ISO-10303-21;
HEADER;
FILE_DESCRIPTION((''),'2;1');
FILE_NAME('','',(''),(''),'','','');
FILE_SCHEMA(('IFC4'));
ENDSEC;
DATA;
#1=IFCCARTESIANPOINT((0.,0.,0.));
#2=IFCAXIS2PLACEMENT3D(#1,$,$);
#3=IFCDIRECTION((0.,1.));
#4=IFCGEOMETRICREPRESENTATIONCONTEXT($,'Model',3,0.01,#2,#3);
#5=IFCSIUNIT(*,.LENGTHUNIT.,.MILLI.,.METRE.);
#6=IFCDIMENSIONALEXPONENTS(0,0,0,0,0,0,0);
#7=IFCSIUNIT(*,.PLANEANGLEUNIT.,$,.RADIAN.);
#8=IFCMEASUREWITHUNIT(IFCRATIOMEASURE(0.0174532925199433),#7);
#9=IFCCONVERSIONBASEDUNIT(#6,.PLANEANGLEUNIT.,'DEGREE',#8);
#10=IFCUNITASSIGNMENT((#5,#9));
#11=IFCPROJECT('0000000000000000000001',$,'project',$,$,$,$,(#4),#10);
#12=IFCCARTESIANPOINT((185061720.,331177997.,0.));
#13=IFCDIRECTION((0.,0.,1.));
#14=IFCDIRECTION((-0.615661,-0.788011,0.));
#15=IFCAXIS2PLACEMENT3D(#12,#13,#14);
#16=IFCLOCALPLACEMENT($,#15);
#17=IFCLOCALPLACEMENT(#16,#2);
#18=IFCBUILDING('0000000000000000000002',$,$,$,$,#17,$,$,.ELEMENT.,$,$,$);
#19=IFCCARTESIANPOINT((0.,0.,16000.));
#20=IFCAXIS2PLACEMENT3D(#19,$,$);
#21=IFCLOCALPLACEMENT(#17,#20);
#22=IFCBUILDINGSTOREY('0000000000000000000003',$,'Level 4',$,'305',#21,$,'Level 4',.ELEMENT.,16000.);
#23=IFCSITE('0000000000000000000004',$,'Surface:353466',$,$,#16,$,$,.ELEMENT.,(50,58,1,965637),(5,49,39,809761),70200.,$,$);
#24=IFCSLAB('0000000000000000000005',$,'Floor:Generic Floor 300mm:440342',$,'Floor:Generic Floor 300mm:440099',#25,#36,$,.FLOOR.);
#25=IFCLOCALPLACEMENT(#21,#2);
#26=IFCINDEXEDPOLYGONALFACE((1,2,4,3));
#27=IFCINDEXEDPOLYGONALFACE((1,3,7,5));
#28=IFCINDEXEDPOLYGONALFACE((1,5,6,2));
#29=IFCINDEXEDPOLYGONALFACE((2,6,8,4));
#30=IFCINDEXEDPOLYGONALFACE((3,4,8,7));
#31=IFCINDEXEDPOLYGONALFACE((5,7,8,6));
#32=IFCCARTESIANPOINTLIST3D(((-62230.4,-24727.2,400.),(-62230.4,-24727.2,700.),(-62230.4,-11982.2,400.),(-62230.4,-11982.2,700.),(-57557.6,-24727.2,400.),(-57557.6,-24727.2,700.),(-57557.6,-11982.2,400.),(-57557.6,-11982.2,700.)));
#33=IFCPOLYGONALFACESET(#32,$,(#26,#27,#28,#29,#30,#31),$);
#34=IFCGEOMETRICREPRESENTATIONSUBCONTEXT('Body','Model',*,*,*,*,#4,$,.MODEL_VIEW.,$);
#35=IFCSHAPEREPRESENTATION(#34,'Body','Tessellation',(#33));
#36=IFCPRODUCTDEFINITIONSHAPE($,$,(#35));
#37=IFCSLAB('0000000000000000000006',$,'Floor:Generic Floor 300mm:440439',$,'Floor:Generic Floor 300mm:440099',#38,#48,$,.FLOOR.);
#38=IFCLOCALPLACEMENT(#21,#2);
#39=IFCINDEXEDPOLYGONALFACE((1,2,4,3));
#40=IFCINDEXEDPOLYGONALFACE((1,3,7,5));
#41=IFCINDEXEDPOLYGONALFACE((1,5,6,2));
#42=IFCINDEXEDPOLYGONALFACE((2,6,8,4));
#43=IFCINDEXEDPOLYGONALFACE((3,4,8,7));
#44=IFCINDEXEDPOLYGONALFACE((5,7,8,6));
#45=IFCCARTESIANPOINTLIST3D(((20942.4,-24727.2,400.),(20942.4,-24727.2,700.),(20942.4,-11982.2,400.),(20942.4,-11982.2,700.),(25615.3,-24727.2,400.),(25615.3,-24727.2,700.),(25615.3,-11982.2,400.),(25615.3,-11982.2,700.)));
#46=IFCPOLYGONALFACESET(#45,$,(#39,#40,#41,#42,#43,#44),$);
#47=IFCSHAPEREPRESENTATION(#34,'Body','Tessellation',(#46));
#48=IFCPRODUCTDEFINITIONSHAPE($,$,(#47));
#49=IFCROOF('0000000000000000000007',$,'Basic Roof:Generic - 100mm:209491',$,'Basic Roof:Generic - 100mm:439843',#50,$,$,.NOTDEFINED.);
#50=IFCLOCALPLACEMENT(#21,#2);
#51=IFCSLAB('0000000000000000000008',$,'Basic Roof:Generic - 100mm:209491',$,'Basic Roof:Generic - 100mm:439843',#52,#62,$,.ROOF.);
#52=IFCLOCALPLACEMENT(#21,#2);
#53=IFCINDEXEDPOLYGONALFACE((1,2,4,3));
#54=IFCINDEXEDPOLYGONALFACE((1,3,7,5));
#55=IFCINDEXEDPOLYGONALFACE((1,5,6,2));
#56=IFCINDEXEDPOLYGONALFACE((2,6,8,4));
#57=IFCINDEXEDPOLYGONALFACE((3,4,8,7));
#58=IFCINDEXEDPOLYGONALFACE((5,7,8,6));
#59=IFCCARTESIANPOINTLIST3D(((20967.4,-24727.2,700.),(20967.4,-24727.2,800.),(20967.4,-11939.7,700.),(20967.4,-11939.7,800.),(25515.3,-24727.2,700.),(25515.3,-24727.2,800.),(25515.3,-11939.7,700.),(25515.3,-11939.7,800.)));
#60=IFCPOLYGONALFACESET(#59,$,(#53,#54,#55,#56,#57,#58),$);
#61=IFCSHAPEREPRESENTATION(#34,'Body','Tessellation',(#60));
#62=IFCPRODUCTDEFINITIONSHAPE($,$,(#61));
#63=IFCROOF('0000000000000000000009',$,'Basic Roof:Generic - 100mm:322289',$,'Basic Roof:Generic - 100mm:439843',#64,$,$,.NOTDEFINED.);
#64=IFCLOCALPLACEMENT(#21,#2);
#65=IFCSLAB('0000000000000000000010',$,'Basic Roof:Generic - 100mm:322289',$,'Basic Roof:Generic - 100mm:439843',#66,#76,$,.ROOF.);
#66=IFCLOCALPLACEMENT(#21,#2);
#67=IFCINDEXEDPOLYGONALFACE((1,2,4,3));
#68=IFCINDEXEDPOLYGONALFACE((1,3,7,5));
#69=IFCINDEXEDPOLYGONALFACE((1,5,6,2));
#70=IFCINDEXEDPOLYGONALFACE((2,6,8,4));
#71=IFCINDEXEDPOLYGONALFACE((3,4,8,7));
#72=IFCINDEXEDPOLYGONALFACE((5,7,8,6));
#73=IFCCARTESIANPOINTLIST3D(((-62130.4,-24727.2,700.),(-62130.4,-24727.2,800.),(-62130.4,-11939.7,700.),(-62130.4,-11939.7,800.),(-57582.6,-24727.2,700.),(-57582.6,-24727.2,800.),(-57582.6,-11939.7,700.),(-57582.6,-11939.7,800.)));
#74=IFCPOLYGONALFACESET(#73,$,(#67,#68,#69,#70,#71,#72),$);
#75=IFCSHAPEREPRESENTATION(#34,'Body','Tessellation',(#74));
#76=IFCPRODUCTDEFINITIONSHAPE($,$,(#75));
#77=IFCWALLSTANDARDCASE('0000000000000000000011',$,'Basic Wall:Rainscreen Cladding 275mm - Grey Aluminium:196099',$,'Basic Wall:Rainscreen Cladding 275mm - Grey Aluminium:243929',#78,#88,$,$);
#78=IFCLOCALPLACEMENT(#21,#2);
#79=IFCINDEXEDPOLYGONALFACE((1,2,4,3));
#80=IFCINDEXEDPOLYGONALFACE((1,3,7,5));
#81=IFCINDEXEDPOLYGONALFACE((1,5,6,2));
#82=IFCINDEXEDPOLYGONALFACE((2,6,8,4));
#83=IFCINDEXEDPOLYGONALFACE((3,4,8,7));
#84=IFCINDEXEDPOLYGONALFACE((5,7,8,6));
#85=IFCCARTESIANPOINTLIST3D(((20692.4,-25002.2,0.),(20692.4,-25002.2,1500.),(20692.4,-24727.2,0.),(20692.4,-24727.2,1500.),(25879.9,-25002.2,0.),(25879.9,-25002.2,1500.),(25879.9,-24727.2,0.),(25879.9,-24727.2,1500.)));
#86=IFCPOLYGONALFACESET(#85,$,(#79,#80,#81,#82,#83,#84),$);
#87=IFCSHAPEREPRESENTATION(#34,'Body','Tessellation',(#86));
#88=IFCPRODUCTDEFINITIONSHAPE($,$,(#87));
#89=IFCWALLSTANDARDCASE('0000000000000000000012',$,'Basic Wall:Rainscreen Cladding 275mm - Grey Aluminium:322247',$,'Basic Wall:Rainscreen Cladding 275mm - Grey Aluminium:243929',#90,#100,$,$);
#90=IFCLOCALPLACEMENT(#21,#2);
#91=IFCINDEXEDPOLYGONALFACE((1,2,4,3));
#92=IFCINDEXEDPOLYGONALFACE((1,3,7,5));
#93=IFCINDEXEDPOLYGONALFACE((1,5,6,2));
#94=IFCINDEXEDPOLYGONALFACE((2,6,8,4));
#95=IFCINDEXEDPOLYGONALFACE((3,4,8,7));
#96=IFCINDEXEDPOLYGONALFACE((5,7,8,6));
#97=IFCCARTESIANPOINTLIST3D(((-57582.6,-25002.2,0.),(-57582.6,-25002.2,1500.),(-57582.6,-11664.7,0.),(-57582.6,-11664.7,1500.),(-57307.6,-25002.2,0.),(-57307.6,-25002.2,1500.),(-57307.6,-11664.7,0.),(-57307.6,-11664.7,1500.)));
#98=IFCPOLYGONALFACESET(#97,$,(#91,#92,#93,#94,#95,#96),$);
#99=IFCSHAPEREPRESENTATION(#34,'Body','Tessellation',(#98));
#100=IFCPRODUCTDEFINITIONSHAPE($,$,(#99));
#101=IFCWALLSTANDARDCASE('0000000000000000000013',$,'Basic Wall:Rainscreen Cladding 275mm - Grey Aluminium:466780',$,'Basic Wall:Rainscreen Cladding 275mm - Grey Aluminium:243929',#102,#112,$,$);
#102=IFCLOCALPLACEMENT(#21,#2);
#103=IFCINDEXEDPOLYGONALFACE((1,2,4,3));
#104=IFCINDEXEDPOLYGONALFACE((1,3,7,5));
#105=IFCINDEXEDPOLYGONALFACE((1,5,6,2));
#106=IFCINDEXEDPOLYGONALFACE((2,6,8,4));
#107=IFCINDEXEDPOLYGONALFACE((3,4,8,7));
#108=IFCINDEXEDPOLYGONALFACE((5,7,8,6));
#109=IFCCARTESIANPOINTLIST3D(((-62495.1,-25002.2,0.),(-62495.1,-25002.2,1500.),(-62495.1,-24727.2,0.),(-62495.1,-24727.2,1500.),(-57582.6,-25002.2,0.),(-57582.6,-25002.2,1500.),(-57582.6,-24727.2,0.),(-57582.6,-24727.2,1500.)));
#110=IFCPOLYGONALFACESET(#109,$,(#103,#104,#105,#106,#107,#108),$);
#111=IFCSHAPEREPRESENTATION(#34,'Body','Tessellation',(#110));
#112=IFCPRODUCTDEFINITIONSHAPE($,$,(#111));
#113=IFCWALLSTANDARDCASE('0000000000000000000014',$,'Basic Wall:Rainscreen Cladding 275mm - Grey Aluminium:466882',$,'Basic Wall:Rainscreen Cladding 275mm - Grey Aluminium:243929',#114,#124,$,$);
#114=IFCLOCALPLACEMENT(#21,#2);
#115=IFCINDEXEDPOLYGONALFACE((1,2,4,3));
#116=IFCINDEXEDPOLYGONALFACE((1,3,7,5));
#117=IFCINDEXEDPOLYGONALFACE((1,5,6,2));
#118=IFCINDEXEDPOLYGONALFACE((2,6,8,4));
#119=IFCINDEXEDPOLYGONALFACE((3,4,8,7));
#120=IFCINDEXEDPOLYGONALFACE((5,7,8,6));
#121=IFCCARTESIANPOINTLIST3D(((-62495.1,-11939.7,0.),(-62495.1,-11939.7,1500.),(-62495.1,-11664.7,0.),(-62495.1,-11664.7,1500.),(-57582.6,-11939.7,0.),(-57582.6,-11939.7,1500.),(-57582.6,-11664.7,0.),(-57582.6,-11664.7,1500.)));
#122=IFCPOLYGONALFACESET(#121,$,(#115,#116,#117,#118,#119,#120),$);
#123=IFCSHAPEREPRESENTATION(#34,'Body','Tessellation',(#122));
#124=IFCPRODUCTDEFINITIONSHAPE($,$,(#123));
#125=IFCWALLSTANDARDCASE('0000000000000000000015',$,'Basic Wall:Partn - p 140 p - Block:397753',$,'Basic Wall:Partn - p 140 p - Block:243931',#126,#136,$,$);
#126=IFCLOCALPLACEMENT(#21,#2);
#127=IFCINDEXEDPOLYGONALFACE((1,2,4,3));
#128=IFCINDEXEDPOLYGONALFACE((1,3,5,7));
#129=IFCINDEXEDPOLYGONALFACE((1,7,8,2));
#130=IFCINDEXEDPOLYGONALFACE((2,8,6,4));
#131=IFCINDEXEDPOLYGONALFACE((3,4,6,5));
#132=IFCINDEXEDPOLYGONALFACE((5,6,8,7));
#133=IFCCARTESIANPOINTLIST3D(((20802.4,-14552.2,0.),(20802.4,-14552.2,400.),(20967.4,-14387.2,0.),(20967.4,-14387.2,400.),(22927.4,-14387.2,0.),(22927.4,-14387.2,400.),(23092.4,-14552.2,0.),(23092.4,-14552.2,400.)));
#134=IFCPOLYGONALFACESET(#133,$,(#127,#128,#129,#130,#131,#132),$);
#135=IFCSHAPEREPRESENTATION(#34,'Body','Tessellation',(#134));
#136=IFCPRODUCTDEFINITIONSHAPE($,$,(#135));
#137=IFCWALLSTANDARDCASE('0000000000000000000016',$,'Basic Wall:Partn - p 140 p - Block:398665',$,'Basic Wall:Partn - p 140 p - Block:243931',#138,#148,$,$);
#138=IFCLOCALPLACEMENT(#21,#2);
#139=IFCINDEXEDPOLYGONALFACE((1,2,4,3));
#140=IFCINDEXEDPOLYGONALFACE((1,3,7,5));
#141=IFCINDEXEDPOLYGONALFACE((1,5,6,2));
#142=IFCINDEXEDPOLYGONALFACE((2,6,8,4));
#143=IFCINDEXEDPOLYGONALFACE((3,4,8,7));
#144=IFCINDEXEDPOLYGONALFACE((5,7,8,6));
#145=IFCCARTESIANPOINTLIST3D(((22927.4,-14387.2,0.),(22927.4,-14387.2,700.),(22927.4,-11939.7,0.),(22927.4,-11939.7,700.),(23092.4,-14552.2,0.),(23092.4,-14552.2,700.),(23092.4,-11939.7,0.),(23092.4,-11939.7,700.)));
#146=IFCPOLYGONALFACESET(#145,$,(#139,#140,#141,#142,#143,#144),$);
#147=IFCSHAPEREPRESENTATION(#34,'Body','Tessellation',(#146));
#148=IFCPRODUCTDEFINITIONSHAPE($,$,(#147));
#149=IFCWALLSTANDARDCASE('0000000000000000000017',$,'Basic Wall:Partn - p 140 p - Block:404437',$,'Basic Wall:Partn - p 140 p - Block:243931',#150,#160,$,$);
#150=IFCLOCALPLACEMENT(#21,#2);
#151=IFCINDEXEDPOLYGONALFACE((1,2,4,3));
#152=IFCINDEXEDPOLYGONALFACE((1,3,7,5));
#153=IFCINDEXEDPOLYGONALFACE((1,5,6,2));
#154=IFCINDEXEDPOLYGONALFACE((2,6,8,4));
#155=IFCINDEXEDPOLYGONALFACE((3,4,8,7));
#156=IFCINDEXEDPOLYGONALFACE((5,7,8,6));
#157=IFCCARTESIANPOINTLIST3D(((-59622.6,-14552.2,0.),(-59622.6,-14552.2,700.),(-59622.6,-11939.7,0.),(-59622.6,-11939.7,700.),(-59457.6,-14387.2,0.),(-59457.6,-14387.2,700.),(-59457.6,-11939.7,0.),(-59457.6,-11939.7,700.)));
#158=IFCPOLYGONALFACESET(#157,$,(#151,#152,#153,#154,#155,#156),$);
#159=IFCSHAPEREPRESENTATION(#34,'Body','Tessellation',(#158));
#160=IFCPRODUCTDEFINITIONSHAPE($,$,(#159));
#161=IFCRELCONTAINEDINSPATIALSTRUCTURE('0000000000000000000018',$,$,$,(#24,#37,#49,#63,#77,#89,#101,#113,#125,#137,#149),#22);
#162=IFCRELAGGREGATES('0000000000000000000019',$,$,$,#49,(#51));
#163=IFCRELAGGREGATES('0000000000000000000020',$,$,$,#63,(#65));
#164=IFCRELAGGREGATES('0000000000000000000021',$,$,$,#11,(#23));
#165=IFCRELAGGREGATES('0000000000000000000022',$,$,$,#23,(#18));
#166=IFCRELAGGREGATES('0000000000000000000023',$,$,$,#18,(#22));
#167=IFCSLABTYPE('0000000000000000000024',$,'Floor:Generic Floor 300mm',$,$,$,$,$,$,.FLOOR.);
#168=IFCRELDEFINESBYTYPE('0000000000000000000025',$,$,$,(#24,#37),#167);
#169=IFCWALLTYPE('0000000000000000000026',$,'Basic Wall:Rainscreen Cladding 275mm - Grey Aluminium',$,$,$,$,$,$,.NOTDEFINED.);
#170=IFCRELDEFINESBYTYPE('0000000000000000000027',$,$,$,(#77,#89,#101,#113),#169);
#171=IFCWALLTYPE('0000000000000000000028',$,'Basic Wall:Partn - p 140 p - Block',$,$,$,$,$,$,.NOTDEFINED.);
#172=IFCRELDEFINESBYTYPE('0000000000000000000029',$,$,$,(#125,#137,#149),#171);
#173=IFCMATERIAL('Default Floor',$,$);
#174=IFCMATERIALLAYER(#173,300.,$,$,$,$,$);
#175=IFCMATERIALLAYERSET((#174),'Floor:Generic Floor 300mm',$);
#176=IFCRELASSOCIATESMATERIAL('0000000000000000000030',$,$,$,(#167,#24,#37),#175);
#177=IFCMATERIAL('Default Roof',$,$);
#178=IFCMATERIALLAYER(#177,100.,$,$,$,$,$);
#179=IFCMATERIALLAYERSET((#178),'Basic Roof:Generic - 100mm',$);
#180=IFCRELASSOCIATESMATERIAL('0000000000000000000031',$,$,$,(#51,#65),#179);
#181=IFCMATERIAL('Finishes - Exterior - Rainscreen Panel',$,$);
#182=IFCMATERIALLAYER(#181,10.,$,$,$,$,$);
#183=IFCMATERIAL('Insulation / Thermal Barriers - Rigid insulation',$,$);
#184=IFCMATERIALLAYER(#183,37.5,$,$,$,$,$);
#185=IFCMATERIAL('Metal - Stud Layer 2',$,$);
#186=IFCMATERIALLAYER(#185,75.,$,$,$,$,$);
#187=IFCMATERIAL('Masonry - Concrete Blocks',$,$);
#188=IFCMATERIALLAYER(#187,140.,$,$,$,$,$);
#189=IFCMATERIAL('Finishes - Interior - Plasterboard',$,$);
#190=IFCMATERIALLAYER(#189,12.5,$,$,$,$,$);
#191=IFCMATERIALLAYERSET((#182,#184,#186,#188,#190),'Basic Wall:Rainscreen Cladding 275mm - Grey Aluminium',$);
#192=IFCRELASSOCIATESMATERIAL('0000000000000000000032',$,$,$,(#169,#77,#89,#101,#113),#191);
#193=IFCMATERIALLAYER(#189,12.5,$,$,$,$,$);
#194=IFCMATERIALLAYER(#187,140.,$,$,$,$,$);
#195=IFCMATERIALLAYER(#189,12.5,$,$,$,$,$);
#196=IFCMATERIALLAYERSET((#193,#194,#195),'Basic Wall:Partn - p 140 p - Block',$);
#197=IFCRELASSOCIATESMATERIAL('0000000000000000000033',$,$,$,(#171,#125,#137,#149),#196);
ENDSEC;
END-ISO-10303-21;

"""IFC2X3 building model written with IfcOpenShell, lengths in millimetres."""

from ifc_helpers import new_model, entity, si_unit, converted_unit, direction, frame, frame_2d, origin, origin_2d_with_axis, place, context, subcontext, project, spatial, polyline, rectangle, outline, extrude, clip, halfspace, bounded_halfspace, material, layer, layer_set, layer_usage, type_object, element, aggregate, save


model = new_model("IFC2X3")

# Units and contexts
model_context = context("Model", 3, precision=0.01, world=origin(), true_north=direction((0.0, 1.0)))
body_context = subcontext(model_context, "Body", "Model", "MODEL_VIEW")
ifc_project = project(units=[si_unit("LENGTHUNIT", "METRE", prefix="MILLI"), converted_unit("PLANEANGLEUNIT", "DEGREE", entity("IfcRatioMeasure", 0.0174532925199433), si_unit("PLANEANGLEUNIT", "RADIAN"), dimensions=[0, 0, 0, 0, 0, 0, 0])], contexts=[model_context])

# Site, building, storey
site_placement = place(None, frame((185061720.0, 331177997.0, 0.0), z_axis=(0.0, 0.0, 1.0), x_axis=(-0.615661, -0.788011, 0.0)))
site = spatial("IfcSite", under=ifc_project, at=site_placement, Name="Surface:353466", CompositionType="ELEMENT", RefLatitude=(50, 58, 1, 965637), RefLongitude=(5, 49, 39, 809761), RefElevation=70200.0)
building_placement = place(site_placement, origin())
building = spatial("IfcBuilding", under=site, at=building_placement, CompositionType="ELEMENT")
storey_placement = place(building_placement, frame((0.0, 0.0, 16000.0)))
storey = spatial("IfcBuildingStorey", under=building, at=storey_placement, Name="Level 4", ObjectType="305", LongName="Level 4", CompositionType="ELEMENT", Elevation=16000.0)

# Slabs
ifc_material_1 = material(Name="Default Floor")
ifc_layer_1 = layer(ifc_material_1, 300.0)
ifc_layer_set_1 = layer_set([ifc_layer_1], Name="Floor:Generic Floor 300mm")
ifc_layer_usage_1 = layer_usage(ifc_layer_set_1, "AXIS3", "POSITIVE", 0.0)
slab_type = type_object("IfcSlabType", Name="Floor:Generic Floor 300mm", PredefinedType="FLOOR", material=ifc_layer_set_1)
slab_1_placement = place(storey_placement, origin())
element("IfcSlab", 1, at=slab_1_placement, inside=storey, type_object=slab_type, material=ifc_layer_usage_1, Name="Floor:Generic Floor 300mm:440342", ObjectType="Floor:Generic Floor 300mm:440099", PredefinedType="FLOOR", context=body_context, shape_type="SweptSolid", body=[
    extrude(rectangle(XDim=12745.0, YDim=4672.9, at=frame_2d((0.0, 0.0), x_axis=(1.0, 0.0))), frame((-59894.0, -18354.7, 700.0), z_axis=(0.0, 0.0, -1.0), x_axis=(0.0, 1.0, 0.0)), (0.0, 0.0, 1.0), 300.0),
])
ifc_layer_usage_2 = layer_usage(ifc_layer_set_1, "AXIS3", "POSITIVE", 0.0)
slab_2_placement = place(storey_placement, origin())
element("IfcSlab", 2, at=slab_2_placement, inside=storey, type_object=slab_type, material=ifc_layer_usage_2, Name="Floor:Generic Floor 300mm:440439", ObjectType="Floor:Generic Floor 300mm:440099", PredefinedType="FLOOR", context=body_context, shape_type="SweptSolid", body=[
    extrude(rectangle(XDim=12745.0, YDim=4672.9, at=origin_2d_with_axis()), frame((23278.9, -18354.7, 700.0), z_axis=(0.0, 0.0, -1.0), x_axis=(0.0, 1.0, 0.0)), (0.0, 0.0, 1.0), 300.0),
])

# Roofs, slabs
roof_1_placement = place(storey_placement, frame((20967.4, -24727.2, 700.0)))
roof_1 = element("IfcRoof", 3, at=roof_1_placement, inside=storey, Name="Basic Roof:Generic - 100mm:209491", ObjectType="Basic Roof:Generic - 100mm:439843", ShapeType="NOTDEFINED")
ifc_material_2 = material(Name="Default Roof")
ifc_layer_2 = layer(ifc_material_2, 100.0)
ifc_layer_set_2 = layer_set([ifc_layer_2], Name="Basic Roof:Generic - 100mm")
slab_3_placement = place(roof_1_placement, origin())
slab_3 = element("IfcSlab", 4, at=slab_3_placement, material=ifc_layer_set_2, Name="Basic Roof:Generic - 100mm:209491", ObjectType="Basic Roof:Generic - 100mm:439843", PredefinedType="ROOF", context=body_context, shape_type="SweptSolid", body=[
    extrude(rectangle(XDim=4547.9, YDim=12787.5, at=frame_2d((0.0, 0.0), x_axis=(1.0, 0.0))), frame((2273.9, 6393.8, 0.0)), (0.0, 0.0, 1.0), 100.0),
])
aggregate(roof_1, [slab_3])
roof_2_placement = place(storey_placement, frame((-62130.4, -24727.2, 700.0)))
roof_2 = element("IfcRoof", 5, at=roof_2_placement, inside=storey, Name="Basic Roof:Generic - 100mm:322289", ObjectType="Basic Roof:Generic - 100mm:439843", ShapeType="NOTDEFINED")
slab_4_placement = place(roof_2_placement, origin())
slab_4 = element("IfcSlab", 6, at=slab_4_placement, material=ifc_layer_set_2, Name="Basic Roof:Generic - 100mm:322289", ObjectType="Basic Roof:Generic - 100mm:439843", PredefinedType="ROOF", context=body_context, shape_type="SweptSolid", body=[
    extrude(rectangle(XDim=4547.9, YDim=12787.5, at=frame_2d((0.0, 0.0), x_axis=(1.0, 0.0))), frame((2273.9, 6393.8, 0.0)), (0.0, 0.0, 1.0), 100.0),
])
aggregate(roof_2, [slab_4])

# Walls
ifc_material_3 = material(Name="Finishes - Exterior - Rainscreen Panel")
ifc_layer_3 = layer(ifc_material_3, 10.0)
ifc_material_4 = material(Name="Insulation / Thermal Barriers - Rigid insulation")
ifc_layer_4 = layer(ifc_material_4, 37.5)
ifc_material_5 = material(Name="Metal - Stud Layer 2")
ifc_layer_5 = layer(ifc_material_5, 75.0)
ifc_material_6 = material(Name="Masonry - Concrete Blocks")
ifc_layer_6 = layer(ifc_material_6, 140.0)
ifc_material_7 = material(Name="Finishes - Interior - Plasterboard")
ifc_layer_7 = layer(ifc_material_7, 12.5)
ifc_layer_set_3 = layer_set([ifc_layer_3, ifc_layer_4, ifc_layer_5, ifc_layer_6, ifc_layer_7], Name="Basic Wall:Rainscreen Cladding 275mm - Grey Aluminium")
ifc_layer_usage_3 = layer_usage(ifc_layer_set_3, "AXIS2", "POSITIVE", -137.5)
wall_type_1 = type_object("IfcWallType", Name="Basic Wall:Rainscreen Cladding 275mm - Grey Aluminium", PredefinedType="NOTDEFINED", material=ifc_layer_set_3)
wall_1_placement = place(storey_placement, frame((20692.4, -24864.7, 0.0)))
element("IfcWallStandardCase", 7, at=wall_1_placement, inside=storey, type_object=wall_type_1, material=ifc_layer_usage_3, Name="Basic Wall:Rainscreen Cladding 275mm - Grey Aluminium:196099", ObjectType="Basic Wall:Rainscreen Cladding 275mm - Grey Aluminium:243929", context=body_context, shape_type="Clipping", body=[
    clip(clip(extrude(rectangle(XDim=5187.5, YDim=275.0, at=frame_2d((2593.8, 0.0), x_axis=(-1.0, 0.0))), origin(), (0.0, 0.0, 1.0), 1500.0), halfspace(frame((0.0, -137.5, 1500.0), z_axis=(0.0, 0.0, 1.0), x_axis=(0.0, 1.0, 0.0)), False)), halfspace(frame((0.0, 0.0, -16000.0)), True)),
])
ifc_layer_usage_4 = layer_usage(ifc_layer_set_3, "AXIS2", "NEGATIVE", 137.5)
wall_2_placement = place(storey_placement, frame((-57445.1, -11664.7, 0.0), z_axis=(0.0, 0.0, 1.0), x_axis=(0.0, -1.0, 0.0)))
element("IfcWallStandardCase", 8, at=wall_2_placement, inside=storey, type_object=wall_type_1, material=ifc_layer_usage_4, Name="Basic Wall:Rainscreen Cladding 275mm - Grey Aluminium:322247", ObjectType="Basic Wall:Rainscreen Cladding 275mm - Grey Aluminium:243929", context=body_context, shape_type="Clipping", body=[
    clip(extrude(rectangle(XDim=13337.5, YDim=275.0, at=frame_2d((6668.8, 0.0), x_axis=(-1.0, 0.0))), origin(), (0.0, 0.0, 1.0), 1500.0), halfspace(frame((0.0, 0.0, -16000.0)), True)),
])
ifc_layer_usage_5 = layer_usage(ifc_layer_set_3, "AXIS2", "POSITIVE", -137.5)
wall_3_placement = place(storey_placement, frame((-62495.1, -24864.7, 0.0)))
element("IfcWallStandardCase", 9, at=wall_3_placement, inside=storey, type_object=wall_type_1, material=ifc_layer_usage_5, Name="Basic Wall:Rainscreen Cladding 275mm - Grey Aluminium:466780", ObjectType="Basic Wall:Rainscreen Cladding 275mm - Grey Aluminium:243929", context=body_context, shape_type="Clipping", body=[
    clip(extrude(rectangle(XDim=4912.5, YDim=275.0, at=frame_2d((2456.3, 0.0), x_axis=(-1.0, 0.0))), origin(), (0.0, 0.0, 1.0), 1500.0), halfspace(frame((0.0, 0.0, -16000.0)), True)),
])
ifc_layer_usage_6 = layer_usage(ifc_layer_set_3, "AXIS2", "POSITIVE", -137.5)
wall_4_placement = place(storey_placement, frame((-57582.6, -11802.2, 0.0), z_axis=(0.0, 0.0, 1.0), x_axis=(-1.0, 0.0, 0.0)))
element("IfcWallStandardCase", 10, at=wall_4_placement, inside=storey, type_object=wall_type_1, material=ifc_layer_usage_6, Name="Basic Wall:Rainscreen Cladding 275mm - Grey Aluminium:466882", ObjectType="Basic Wall:Rainscreen Cladding 275mm - Grey Aluminium:243929", context=body_context, shape_type="Clipping", body=[
    clip(extrude(rectangle(XDim=4912.5, YDim=275.0, at=frame_2d((2456.3, 0.0), x_axis=(-1.0, 0.0))), origin(), (0.0, 0.0, 1.0), 1500.0), halfspace(frame((0.0, 0.0, -16000.0)), True)),
])
ifc_layer_8 = layer(ifc_material_7, 12.5)
ifc_layer_9 = layer(ifc_material_6, 140.0)
ifc_layer_10 = layer(ifc_material_7, 12.5)
ifc_layer_set_4 = layer_set([ifc_layer_8, ifc_layer_9, ifc_layer_10], Name="Basic Wall:Partn - p 140 p - Block")
ifc_layer_usage_7 = layer_usage(ifc_layer_set_4, "AXIS2", "NEGATIVE", 82.5)
wall_type_2 = type_object("IfcWallType", Name="Basic Wall:Partn - p 140 p - Block", PredefinedType="NOTDEFINED", material=ifc_layer_set_4)
wall_5_placement = place(storey_placement, frame((23092.4, -14469.7, 0.0), z_axis=(0.0, 0.0, 1.0), x_axis=(-1.0, 0.0, 0.0)))
element("IfcWallStandardCase", 11, at=wall_5_placement, inside=storey, type_object=wall_type_2, material=ifc_layer_usage_7, Name="Basic Wall:Partn - p 140 p - Block:397753", ObjectType="Basic Wall:Partn - p 140 p - Block:243931", context=body_context, shape_type="Clipping", body=[
    clip(extrude(outline(polyline([(2125.0, -82.5), (2290.0, 82.5), (0.0, 82.5), (165.0, -82.5), (2125.0, -82.5)])), origin(), (0.0, 0.0, 1.0), 400.0), halfspace(frame((0.0, 0.0, -16000.0)), True)),
])
ifc_layer_usage_8 = layer_usage(ifc_layer_set_4, "AXIS2", "NEGATIVE", 82.5)
wall_6_placement = place(storey_placement, frame((23009.9, -14552.2, 0.0), z_axis=(0.0, 0.0, 1.0), x_axis=(0.0, 1.0, 0.0)))
element("IfcWallStandardCase", 12, at=wall_6_placement, inside=storey, type_object=wall_type_2, material=ifc_layer_usage_8, Name="Basic Wall:Partn - p 140 p - Block:398665", ObjectType="Basic Wall:Partn - p 140 p - Block:243931", context=body_context, shape_type="Clipping", body=[
    clip(clip(extrude(outline(polyline([(2612.5, -82.5), (2612.5, 82.5), (165.0, 82.5), (0.0, -82.5), (2612.5, -82.5)])), origin(), (0.0, 0.0, 1.0), 700.0), bounded_halfspace(frame((0.0, -82.5, 700.0), z_axis=(0.0, 0.0, 1.0), x_axis=(0.0, -1.0, 0.0)), False, frame((0.0, -82.5, 700.0)), polyline([(0.0, 0.0), (2612.5, 0.0), (2612.5, 165.0), (165.0, 165.0), (0.0, 0.0)]))), halfspace(frame((0.0, 0.0, -16000.0)), True)),
])
ifc_layer_usage_9 = layer_usage(ifc_layer_set_4, "AXIS2", "NEGATIVE", 82.5)
wall_7_placement = place(storey_placement, frame((-59540.1, -11939.7, 0.0), z_axis=(0.0, 0.0, 1.0), x_axis=(0.0, -1.0, 0.0)))
element("IfcWallStandardCase", 13, at=wall_7_placement, inside=storey, type_object=wall_type_2, material=ifc_layer_usage_9, Name="Basic Wall:Partn - p 140 p - Block:404437", ObjectType="Basic Wall:Partn - p 140 p - Block:243931", context=body_context, shape_type="Clipping", body=[
    clip(clip(extrude(outline(polyline([(2612.5, -82.5), (2447.5, 82.5), (0.0, 82.5), (0.0, -82.5), (2447.5, -82.5), (2612.5, -82.5)])), origin(), (0.0, 0.0, 1.0), 700.0), bounded_halfspace(frame((0.0, -82.5, 700.0), z_axis=(0.0, 0.0, 1.0), x_axis=(0.0, 1.0, 0.0)), False, frame((0.0, -82.5, 700.0)), polyline([(0.0, 0.0), (2612.5, 0.0), (2447.5, 165.0), (0.0, 165.0), (0.0, 0.0)]))), halfspace(frame((0.0, 0.0, -4000.0)), True)),
])

save(model, "model.ifc")
